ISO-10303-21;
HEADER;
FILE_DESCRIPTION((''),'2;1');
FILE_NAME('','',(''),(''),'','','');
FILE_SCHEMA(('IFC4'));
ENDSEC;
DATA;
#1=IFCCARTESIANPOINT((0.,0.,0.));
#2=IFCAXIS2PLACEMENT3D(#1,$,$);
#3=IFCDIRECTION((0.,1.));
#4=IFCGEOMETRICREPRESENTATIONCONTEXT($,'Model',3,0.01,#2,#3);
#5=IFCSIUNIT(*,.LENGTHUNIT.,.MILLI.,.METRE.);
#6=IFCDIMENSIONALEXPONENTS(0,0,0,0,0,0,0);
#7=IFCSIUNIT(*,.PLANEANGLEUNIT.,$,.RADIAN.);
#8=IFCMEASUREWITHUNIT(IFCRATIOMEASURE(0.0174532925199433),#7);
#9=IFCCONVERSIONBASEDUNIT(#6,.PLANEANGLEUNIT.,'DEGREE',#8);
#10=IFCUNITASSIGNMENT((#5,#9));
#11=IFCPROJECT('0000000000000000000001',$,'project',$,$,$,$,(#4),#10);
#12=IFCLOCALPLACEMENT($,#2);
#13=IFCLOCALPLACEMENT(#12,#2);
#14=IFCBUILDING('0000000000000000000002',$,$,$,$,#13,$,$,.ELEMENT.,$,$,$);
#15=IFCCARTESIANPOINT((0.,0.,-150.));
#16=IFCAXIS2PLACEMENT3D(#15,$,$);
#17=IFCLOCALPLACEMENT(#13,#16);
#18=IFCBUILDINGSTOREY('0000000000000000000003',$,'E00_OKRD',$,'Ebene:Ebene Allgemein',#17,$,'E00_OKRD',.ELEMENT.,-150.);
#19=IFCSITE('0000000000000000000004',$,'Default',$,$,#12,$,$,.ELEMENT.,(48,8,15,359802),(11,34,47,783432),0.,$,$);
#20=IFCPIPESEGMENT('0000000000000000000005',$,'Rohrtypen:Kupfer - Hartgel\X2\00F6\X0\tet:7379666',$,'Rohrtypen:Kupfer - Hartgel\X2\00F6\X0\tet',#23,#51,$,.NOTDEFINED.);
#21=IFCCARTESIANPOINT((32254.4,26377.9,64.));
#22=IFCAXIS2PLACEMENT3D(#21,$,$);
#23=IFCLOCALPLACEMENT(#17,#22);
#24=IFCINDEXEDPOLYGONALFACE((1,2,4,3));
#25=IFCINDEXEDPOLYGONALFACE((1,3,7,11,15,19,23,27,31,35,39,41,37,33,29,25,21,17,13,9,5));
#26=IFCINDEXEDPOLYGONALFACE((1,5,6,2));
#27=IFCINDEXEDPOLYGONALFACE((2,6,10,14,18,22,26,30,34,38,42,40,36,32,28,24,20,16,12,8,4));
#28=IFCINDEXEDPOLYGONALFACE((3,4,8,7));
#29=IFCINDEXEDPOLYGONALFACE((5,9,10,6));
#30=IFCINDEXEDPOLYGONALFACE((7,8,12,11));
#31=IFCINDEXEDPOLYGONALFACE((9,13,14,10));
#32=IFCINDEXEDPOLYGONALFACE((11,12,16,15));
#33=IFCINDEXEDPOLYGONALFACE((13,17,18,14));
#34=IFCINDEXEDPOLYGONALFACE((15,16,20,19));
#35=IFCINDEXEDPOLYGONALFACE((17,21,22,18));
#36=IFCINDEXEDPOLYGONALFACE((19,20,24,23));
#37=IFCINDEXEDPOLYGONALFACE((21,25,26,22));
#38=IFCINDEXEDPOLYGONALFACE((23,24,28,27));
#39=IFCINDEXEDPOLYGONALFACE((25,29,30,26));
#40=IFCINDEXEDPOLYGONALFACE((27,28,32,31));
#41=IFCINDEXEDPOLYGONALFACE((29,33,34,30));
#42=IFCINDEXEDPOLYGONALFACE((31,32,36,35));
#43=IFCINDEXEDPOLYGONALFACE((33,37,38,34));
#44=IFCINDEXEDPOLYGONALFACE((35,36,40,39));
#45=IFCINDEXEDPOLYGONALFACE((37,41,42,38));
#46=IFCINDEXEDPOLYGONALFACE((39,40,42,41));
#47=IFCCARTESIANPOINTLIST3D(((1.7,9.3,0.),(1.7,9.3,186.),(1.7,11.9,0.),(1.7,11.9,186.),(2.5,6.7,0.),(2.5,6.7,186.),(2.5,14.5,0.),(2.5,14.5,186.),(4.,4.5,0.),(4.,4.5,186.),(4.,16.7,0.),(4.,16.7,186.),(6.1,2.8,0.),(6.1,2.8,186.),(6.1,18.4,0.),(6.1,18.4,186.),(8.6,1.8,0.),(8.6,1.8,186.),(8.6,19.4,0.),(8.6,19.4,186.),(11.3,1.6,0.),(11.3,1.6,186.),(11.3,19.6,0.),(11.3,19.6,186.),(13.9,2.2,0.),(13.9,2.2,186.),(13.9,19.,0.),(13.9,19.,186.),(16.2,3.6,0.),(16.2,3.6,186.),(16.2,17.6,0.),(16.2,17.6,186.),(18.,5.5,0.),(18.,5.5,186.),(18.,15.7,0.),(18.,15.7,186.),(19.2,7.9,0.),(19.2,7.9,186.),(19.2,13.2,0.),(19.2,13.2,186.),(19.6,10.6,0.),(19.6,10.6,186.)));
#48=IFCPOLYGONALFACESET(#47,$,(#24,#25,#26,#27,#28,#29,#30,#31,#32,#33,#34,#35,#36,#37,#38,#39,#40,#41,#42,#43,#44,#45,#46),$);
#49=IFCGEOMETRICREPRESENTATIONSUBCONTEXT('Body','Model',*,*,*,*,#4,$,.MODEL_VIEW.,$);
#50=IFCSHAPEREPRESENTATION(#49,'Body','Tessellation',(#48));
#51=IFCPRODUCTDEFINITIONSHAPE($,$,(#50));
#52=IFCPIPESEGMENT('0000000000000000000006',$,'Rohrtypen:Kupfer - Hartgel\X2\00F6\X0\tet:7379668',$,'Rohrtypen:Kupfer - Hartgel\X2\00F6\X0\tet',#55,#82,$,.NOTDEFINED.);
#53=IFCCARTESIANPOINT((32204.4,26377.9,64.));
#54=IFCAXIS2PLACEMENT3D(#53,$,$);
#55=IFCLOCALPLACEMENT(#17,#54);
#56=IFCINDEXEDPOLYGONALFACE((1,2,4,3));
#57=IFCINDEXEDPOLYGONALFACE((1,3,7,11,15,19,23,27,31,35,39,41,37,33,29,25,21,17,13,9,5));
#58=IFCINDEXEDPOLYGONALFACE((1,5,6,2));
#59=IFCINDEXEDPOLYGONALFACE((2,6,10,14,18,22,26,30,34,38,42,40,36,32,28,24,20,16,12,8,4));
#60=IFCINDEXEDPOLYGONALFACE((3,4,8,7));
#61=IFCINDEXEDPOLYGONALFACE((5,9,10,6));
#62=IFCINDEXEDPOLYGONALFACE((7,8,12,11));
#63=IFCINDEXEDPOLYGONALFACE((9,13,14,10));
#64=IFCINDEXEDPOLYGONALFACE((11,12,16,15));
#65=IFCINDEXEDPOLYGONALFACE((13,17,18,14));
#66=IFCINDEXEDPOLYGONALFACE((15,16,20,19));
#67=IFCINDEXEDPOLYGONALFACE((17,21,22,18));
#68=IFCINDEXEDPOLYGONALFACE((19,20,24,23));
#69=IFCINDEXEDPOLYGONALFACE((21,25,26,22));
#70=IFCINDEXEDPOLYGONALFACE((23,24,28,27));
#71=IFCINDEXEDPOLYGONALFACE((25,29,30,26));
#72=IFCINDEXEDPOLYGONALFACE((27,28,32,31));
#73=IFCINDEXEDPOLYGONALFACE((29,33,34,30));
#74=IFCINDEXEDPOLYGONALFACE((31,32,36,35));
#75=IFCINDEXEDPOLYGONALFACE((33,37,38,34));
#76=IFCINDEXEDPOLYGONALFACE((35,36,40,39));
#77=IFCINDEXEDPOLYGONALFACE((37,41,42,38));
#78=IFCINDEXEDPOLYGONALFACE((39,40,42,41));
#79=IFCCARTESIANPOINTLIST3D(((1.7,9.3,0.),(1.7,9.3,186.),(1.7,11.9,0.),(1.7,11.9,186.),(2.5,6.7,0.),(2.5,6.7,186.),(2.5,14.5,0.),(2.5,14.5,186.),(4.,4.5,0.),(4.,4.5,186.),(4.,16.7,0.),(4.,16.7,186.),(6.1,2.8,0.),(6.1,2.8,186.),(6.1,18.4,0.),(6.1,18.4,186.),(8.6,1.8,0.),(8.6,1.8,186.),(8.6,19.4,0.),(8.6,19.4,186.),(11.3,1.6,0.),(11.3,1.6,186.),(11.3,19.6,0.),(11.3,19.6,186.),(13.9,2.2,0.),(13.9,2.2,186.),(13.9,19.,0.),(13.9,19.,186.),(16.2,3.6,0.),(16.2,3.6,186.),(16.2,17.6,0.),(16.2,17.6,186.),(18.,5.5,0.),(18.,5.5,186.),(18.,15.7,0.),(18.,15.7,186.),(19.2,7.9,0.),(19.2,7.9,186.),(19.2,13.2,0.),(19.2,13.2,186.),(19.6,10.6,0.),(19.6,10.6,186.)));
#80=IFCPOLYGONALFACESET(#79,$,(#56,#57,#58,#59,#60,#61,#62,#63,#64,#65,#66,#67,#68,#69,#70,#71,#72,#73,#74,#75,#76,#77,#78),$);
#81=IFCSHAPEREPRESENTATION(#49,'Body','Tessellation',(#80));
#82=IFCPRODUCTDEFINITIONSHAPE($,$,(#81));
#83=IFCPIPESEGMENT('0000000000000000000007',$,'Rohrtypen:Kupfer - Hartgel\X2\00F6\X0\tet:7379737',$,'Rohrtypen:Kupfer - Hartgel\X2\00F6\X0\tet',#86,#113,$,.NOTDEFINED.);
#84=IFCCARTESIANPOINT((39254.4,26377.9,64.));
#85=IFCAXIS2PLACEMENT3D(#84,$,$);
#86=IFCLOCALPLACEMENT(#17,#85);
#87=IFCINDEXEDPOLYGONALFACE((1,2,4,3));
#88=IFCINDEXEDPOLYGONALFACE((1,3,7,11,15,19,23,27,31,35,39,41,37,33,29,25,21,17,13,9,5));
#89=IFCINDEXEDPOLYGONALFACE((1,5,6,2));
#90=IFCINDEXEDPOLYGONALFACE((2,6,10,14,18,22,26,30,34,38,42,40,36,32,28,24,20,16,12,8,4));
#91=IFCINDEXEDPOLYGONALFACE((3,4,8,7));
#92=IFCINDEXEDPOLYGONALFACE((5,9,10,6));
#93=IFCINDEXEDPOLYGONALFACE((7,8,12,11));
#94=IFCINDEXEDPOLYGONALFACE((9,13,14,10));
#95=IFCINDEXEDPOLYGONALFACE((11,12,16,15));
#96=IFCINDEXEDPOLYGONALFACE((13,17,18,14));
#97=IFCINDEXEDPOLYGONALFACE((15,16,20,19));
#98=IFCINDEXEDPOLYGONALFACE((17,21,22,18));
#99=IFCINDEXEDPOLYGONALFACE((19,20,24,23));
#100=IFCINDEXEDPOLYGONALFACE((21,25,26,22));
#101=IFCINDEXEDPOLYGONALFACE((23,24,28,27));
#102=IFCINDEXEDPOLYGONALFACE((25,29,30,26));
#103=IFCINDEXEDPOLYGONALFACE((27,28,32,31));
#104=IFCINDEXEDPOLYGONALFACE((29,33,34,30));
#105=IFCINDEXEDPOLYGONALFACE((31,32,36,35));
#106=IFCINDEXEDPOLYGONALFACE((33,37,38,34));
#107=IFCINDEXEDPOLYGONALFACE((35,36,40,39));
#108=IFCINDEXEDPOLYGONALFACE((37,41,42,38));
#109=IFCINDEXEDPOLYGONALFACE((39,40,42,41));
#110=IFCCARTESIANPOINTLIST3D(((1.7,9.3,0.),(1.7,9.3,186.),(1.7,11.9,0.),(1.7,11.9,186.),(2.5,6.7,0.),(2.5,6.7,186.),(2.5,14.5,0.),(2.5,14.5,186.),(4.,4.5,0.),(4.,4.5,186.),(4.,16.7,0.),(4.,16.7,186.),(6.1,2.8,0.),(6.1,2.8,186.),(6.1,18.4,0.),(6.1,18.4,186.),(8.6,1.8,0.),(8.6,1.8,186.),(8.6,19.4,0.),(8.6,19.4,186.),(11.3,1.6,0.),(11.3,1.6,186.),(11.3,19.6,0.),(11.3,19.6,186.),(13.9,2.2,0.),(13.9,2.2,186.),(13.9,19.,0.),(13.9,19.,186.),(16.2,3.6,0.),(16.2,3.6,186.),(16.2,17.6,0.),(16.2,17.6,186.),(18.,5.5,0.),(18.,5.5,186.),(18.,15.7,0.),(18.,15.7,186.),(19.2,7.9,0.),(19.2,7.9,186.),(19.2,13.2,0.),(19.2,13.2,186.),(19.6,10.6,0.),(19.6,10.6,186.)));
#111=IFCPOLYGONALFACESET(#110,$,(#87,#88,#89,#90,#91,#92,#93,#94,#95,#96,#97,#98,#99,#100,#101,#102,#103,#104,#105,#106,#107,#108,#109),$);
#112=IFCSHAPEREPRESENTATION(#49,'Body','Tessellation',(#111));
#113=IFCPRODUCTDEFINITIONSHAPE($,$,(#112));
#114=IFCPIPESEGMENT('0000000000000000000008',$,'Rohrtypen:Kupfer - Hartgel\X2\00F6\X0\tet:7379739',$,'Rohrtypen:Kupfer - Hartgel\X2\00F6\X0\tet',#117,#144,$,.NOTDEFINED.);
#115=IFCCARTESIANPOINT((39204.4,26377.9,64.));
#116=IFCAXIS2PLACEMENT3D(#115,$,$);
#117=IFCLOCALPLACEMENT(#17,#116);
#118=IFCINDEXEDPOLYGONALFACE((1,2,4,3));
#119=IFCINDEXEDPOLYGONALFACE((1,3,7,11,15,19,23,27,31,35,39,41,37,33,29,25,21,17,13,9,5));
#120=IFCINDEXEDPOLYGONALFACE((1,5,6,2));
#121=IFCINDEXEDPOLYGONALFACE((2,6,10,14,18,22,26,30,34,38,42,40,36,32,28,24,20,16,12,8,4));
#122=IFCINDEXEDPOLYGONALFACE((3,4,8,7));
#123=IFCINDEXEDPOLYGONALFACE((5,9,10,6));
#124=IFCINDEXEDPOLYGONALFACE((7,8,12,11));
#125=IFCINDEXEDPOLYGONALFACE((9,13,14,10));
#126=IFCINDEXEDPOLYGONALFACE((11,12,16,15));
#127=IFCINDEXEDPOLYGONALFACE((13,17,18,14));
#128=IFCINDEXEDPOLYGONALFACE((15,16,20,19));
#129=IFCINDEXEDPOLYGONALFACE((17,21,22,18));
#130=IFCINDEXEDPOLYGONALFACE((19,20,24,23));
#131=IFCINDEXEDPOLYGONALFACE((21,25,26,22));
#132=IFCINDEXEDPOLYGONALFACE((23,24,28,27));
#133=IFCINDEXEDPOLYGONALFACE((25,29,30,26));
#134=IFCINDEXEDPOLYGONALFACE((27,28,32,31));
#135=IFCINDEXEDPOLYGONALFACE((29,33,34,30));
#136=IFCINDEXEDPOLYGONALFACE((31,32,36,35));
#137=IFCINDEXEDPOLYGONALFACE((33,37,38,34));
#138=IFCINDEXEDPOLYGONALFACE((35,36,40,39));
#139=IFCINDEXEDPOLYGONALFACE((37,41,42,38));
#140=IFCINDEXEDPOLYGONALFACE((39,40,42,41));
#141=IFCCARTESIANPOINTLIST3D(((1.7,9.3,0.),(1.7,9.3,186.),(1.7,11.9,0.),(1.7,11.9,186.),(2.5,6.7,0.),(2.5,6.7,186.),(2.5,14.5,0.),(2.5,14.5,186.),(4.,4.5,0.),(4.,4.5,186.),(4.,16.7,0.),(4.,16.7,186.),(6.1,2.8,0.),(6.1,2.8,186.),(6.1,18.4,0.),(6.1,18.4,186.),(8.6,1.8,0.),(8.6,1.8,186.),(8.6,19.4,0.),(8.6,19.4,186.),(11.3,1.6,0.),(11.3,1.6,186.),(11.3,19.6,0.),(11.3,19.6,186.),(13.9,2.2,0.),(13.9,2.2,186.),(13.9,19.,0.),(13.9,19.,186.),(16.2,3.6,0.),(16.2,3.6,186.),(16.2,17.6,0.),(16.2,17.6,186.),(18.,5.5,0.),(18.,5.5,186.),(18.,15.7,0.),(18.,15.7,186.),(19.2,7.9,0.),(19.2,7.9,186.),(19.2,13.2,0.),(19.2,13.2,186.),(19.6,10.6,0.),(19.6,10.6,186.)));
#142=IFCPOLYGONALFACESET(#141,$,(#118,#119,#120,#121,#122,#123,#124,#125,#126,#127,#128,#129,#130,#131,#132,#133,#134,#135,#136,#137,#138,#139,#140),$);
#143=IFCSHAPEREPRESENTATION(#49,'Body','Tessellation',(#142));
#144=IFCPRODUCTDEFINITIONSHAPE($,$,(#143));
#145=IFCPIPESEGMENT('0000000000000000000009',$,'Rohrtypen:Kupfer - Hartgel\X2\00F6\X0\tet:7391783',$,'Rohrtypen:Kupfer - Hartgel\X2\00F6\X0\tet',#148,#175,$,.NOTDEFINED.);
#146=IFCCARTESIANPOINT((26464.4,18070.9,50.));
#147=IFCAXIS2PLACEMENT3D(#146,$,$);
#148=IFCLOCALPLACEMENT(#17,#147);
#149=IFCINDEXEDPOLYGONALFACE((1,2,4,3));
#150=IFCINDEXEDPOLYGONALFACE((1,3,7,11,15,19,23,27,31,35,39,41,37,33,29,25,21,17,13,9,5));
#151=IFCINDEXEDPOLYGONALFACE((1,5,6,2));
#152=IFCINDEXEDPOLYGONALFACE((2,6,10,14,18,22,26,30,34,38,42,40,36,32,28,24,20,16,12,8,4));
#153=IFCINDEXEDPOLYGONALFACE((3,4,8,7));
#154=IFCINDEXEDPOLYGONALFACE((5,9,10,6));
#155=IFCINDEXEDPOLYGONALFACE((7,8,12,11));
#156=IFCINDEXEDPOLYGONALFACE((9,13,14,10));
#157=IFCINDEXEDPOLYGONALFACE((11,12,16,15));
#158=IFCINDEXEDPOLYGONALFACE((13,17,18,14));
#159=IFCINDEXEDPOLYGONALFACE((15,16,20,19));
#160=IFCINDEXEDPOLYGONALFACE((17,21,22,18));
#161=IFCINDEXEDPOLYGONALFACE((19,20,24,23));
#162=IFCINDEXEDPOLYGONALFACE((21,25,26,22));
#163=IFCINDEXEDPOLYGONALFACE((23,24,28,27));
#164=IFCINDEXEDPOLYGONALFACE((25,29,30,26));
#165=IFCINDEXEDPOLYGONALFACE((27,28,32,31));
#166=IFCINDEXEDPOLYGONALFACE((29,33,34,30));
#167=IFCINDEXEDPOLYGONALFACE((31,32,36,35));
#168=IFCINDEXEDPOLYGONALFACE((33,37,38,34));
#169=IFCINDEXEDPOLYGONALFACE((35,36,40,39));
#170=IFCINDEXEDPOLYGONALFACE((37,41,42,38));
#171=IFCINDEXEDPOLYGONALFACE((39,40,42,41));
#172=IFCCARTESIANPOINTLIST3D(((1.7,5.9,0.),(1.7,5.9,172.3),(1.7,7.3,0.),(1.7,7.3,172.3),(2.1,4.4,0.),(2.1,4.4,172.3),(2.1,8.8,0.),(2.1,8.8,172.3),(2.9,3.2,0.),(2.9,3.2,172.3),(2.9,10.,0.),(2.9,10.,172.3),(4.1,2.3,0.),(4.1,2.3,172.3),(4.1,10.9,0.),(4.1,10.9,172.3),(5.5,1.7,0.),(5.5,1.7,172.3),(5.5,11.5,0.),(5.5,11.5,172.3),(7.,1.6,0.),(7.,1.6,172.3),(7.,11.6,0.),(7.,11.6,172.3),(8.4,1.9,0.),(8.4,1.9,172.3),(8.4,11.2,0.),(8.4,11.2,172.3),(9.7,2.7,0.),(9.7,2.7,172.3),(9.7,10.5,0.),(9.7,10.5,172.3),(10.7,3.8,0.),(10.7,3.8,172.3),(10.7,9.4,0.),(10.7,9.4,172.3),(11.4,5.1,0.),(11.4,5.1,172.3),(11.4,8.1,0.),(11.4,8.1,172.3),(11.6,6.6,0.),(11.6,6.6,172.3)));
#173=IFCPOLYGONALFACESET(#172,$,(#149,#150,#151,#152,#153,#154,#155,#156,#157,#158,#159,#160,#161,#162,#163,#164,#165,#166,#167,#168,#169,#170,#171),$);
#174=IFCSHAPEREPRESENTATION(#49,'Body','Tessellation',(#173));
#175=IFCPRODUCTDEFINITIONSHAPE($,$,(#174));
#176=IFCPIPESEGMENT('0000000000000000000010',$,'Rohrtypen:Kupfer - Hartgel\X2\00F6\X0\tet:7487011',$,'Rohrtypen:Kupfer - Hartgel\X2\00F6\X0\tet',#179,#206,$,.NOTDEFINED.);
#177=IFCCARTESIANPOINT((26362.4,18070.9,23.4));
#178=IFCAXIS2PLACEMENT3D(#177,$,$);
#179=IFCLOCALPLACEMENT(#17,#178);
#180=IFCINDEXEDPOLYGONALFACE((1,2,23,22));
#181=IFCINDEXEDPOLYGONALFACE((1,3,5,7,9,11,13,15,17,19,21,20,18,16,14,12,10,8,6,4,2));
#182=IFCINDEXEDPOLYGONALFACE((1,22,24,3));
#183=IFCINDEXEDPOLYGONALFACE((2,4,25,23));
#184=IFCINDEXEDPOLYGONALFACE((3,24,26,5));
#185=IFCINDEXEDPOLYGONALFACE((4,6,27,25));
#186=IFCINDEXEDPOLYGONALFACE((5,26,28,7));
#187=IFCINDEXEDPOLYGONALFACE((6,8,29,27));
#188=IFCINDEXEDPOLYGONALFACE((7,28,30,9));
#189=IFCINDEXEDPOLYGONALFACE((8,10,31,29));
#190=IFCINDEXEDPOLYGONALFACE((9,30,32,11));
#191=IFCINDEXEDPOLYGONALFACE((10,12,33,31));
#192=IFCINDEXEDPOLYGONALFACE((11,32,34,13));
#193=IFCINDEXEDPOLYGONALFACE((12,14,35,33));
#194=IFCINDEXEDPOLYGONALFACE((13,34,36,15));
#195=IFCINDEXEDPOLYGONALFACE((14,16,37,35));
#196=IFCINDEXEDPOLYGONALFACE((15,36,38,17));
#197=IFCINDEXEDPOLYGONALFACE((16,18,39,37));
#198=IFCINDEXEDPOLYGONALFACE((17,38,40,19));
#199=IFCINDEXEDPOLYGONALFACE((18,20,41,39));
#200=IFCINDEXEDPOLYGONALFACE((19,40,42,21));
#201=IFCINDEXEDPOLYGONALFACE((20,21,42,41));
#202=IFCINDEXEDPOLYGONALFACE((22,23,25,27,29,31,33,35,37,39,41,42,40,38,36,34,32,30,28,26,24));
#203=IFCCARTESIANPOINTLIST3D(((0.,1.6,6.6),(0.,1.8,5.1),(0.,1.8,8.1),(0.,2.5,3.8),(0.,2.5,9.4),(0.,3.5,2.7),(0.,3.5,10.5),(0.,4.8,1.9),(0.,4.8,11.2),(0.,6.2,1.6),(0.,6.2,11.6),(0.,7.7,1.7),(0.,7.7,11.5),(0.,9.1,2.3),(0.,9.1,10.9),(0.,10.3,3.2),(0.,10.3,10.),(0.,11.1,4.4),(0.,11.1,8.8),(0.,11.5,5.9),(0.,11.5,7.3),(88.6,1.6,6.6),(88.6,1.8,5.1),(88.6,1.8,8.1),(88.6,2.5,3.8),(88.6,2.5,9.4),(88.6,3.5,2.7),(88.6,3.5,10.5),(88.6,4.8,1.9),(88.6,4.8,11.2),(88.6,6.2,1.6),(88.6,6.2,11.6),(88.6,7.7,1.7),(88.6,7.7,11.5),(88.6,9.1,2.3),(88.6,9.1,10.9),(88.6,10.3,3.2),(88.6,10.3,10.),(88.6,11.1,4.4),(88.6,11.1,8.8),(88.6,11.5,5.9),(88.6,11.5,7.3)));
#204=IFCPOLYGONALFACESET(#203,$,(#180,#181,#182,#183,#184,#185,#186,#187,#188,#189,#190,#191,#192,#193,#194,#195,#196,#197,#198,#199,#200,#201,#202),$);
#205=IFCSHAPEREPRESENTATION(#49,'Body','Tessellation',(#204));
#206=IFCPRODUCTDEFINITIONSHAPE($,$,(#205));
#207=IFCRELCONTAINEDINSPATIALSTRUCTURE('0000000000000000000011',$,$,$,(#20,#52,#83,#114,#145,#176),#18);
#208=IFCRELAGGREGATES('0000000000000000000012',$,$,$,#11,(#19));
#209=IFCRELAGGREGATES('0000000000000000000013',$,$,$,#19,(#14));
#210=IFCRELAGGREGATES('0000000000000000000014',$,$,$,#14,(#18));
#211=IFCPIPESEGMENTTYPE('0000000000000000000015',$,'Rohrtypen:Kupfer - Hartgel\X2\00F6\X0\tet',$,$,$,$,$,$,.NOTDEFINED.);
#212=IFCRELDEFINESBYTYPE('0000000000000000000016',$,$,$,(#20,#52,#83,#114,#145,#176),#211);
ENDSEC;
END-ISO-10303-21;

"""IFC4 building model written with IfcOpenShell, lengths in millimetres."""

from ifc_helpers import new_model, entity, si_unit, converted_unit, direction, frame, frame_2d, origin, origin_2d_with_axis, place, context, subcontext, project, spatial, circle, extrude, type_object, element, save


model = new_model("IFC4")

# Units and contexts
model_context = context("Model", 3, precision=0.01, world=origin(), true_north=direction((0.0, 1.0)))
body_context = subcontext(model_context, "Body", "Model", "MODEL_VIEW")
ifc_project = project(units=[si_unit("LENGTHUNIT", "METRE", prefix="MILLI"), converted_unit("PLANEANGLEUNIT", "DEGREE", entity("IfcRatioMeasure", 0.0174532925199433), si_unit("PLANEANGLEUNIT", "RADIAN"), dimensions=[0, 0, 0, 0, 0, 0, 0])], contexts=[model_context])

# Site, building, storey
site_placement = place(None, origin())
site = spatial("IfcSite", under=ifc_project, at=site_placement, Name="Default", CompositionType="ELEMENT", RefLatitude=(48, 8, 15, 359802), RefLongitude=(11, 34, 47, 783432), RefElevation=0.0)
building_placement = place(site_placement, origin())
building = spatial("IfcBuilding", under=site, at=building_placement, CompositionType="ELEMENT")
storey_placement = place(building_placement, frame((0.0, 0.0, -150.0)))
storey = spatial("IfcBuildingStorey", under=building, at=storey_placement, Name="E00_OKRD", ObjectType="Ebene:Ebene Allgemein", LongName="E00_OKRD", CompositionType="ELEMENT", Elevation=-150.0)

# Pipe segments
pipe_segment_type = type_object("IfcPipeSegmentType", Name="Rohrtypen:Kupfer - Hartgelötet", PredefinedType="NOTDEFINED")
pipe_segment_1_placement = place(storey_placement, frame((32254.4, 26377.9, 64.0)))
element("IfcPipeSegment", 1, at=pipe_segment_1_placement, inside=storey, type_object=pipe_segment_type, Name="Rohrtypen:Kupfer - Hartgelötet:7379666", ObjectType="Rohrtypen:Kupfer - Hartgelötet", PredefinedType="NOTDEFINED", context=body_context, shape_type="SweptSolid", body=[
    extrude(circle(Radius=9.0, at=origin_2d_with_axis()), frame((10.6, 10.6, 0.0)), (0.0, 0.0, 1.0), 186.0),
])
pipe_segment_2_placement = place(storey_placement, frame((32204.4, 26377.9, 64.0)))
element("IfcPipeSegment", 2, at=pipe_segment_2_placement, inside=storey, type_object=pipe_segment_type, Name="Rohrtypen:Kupfer - Hartgelötet:7379668", ObjectType="Rohrtypen:Kupfer - Hartgelötet", PredefinedType="NOTDEFINED", context=body_context, shape_type="SweptSolid", body=[
    extrude(circle(Radius=9.0, at=origin_2d_with_axis()), frame((10.6, 10.6, 0.0)), (0.0, 0.0, 1.0), 186.0),
])
pipe_segment_3_placement = place(storey_placement, frame((39254.4, 26377.9, 64.0)))
element("IfcPipeSegment", 3, at=pipe_segment_3_placement, inside=storey, type_object=pipe_segment_type, Name="Rohrtypen:Kupfer - Hartgelötet:7379737", ObjectType="Rohrtypen:Kupfer - Hartgelötet", PredefinedType="NOTDEFINED", context=body_context, shape_type="SweptSolid", body=[
    extrude(circle(Radius=9.0, at=origin_2d_with_axis()), frame((10.6, 10.6, 0.0)), (0.0, 0.0, 1.0), 186.0),
])
pipe_segment_4_placement = place(storey_placement, frame((39204.4, 26377.9, 64.0)))
element("IfcPipeSegment", 4, at=pipe_segment_4_placement, inside=storey, type_object=pipe_segment_type, Name="Rohrtypen:Kupfer - Hartgelötet:7379739", ObjectType="Rohrtypen:Kupfer - Hartgelötet", PredefinedType="NOTDEFINED", context=body_context, shape_type="SweptSolid", body=[
    extrude(circle(Radius=9.0, at=origin_2d_with_axis()), frame((10.6, 10.6, 0.0)), (0.0, 0.0, 1.0), 186.0),
])
pipe_segment_5_placement = place(storey_placement, frame((26464.4, 18070.9, 50.0)))
element("IfcPipeSegment", 5, at=pipe_segment_5_placement, inside=storey, type_object=pipe_segment_type, Name="Rohrtypen:Kupfer - Hartgelötet:7391783", ObjectType="Rohrtypen:Kupfer - Hartgelötet", PredefinedType="NOTDEFINED", context=body_context, shape_type="SweptSolid", body=[
    extrude(circle(Radius=5.0, at=origin_2d_with_axis()), frame((6.6, 6.6, 0.0)), (0.0, 0.0, 1.0), 172.3),
])
pipe_segment_6_placement = place(storey_placement, frame((26362.4, 18070.9, 23.4)))
element("IfcPipeSegment", 6, at=pipe_segment_6_placement, inside=storey, type_object=pipe_segment_type, Name="Rohrtypen:Kupfer - Hartgelötet:7487011", ObjectType="Rohrtypen:Kupfer - Hartgelötet", PredefinedType="NOTDEFINED", context=body_context, shape_type="SweptSolid", body=[
    extrude(circle(Radius=5.0, at=frame_2d((0.0, 0.0), x_axis=(1.0, 0.0))), frame((0.0, 6.6, 6.6), z_axis=(1.0, 0.0, 0.0), x_axis=(0.0, -1.0, 0.0)), (0.0, 0.0, 1.0), 88.6),
])

save(model, "model.ifc")
